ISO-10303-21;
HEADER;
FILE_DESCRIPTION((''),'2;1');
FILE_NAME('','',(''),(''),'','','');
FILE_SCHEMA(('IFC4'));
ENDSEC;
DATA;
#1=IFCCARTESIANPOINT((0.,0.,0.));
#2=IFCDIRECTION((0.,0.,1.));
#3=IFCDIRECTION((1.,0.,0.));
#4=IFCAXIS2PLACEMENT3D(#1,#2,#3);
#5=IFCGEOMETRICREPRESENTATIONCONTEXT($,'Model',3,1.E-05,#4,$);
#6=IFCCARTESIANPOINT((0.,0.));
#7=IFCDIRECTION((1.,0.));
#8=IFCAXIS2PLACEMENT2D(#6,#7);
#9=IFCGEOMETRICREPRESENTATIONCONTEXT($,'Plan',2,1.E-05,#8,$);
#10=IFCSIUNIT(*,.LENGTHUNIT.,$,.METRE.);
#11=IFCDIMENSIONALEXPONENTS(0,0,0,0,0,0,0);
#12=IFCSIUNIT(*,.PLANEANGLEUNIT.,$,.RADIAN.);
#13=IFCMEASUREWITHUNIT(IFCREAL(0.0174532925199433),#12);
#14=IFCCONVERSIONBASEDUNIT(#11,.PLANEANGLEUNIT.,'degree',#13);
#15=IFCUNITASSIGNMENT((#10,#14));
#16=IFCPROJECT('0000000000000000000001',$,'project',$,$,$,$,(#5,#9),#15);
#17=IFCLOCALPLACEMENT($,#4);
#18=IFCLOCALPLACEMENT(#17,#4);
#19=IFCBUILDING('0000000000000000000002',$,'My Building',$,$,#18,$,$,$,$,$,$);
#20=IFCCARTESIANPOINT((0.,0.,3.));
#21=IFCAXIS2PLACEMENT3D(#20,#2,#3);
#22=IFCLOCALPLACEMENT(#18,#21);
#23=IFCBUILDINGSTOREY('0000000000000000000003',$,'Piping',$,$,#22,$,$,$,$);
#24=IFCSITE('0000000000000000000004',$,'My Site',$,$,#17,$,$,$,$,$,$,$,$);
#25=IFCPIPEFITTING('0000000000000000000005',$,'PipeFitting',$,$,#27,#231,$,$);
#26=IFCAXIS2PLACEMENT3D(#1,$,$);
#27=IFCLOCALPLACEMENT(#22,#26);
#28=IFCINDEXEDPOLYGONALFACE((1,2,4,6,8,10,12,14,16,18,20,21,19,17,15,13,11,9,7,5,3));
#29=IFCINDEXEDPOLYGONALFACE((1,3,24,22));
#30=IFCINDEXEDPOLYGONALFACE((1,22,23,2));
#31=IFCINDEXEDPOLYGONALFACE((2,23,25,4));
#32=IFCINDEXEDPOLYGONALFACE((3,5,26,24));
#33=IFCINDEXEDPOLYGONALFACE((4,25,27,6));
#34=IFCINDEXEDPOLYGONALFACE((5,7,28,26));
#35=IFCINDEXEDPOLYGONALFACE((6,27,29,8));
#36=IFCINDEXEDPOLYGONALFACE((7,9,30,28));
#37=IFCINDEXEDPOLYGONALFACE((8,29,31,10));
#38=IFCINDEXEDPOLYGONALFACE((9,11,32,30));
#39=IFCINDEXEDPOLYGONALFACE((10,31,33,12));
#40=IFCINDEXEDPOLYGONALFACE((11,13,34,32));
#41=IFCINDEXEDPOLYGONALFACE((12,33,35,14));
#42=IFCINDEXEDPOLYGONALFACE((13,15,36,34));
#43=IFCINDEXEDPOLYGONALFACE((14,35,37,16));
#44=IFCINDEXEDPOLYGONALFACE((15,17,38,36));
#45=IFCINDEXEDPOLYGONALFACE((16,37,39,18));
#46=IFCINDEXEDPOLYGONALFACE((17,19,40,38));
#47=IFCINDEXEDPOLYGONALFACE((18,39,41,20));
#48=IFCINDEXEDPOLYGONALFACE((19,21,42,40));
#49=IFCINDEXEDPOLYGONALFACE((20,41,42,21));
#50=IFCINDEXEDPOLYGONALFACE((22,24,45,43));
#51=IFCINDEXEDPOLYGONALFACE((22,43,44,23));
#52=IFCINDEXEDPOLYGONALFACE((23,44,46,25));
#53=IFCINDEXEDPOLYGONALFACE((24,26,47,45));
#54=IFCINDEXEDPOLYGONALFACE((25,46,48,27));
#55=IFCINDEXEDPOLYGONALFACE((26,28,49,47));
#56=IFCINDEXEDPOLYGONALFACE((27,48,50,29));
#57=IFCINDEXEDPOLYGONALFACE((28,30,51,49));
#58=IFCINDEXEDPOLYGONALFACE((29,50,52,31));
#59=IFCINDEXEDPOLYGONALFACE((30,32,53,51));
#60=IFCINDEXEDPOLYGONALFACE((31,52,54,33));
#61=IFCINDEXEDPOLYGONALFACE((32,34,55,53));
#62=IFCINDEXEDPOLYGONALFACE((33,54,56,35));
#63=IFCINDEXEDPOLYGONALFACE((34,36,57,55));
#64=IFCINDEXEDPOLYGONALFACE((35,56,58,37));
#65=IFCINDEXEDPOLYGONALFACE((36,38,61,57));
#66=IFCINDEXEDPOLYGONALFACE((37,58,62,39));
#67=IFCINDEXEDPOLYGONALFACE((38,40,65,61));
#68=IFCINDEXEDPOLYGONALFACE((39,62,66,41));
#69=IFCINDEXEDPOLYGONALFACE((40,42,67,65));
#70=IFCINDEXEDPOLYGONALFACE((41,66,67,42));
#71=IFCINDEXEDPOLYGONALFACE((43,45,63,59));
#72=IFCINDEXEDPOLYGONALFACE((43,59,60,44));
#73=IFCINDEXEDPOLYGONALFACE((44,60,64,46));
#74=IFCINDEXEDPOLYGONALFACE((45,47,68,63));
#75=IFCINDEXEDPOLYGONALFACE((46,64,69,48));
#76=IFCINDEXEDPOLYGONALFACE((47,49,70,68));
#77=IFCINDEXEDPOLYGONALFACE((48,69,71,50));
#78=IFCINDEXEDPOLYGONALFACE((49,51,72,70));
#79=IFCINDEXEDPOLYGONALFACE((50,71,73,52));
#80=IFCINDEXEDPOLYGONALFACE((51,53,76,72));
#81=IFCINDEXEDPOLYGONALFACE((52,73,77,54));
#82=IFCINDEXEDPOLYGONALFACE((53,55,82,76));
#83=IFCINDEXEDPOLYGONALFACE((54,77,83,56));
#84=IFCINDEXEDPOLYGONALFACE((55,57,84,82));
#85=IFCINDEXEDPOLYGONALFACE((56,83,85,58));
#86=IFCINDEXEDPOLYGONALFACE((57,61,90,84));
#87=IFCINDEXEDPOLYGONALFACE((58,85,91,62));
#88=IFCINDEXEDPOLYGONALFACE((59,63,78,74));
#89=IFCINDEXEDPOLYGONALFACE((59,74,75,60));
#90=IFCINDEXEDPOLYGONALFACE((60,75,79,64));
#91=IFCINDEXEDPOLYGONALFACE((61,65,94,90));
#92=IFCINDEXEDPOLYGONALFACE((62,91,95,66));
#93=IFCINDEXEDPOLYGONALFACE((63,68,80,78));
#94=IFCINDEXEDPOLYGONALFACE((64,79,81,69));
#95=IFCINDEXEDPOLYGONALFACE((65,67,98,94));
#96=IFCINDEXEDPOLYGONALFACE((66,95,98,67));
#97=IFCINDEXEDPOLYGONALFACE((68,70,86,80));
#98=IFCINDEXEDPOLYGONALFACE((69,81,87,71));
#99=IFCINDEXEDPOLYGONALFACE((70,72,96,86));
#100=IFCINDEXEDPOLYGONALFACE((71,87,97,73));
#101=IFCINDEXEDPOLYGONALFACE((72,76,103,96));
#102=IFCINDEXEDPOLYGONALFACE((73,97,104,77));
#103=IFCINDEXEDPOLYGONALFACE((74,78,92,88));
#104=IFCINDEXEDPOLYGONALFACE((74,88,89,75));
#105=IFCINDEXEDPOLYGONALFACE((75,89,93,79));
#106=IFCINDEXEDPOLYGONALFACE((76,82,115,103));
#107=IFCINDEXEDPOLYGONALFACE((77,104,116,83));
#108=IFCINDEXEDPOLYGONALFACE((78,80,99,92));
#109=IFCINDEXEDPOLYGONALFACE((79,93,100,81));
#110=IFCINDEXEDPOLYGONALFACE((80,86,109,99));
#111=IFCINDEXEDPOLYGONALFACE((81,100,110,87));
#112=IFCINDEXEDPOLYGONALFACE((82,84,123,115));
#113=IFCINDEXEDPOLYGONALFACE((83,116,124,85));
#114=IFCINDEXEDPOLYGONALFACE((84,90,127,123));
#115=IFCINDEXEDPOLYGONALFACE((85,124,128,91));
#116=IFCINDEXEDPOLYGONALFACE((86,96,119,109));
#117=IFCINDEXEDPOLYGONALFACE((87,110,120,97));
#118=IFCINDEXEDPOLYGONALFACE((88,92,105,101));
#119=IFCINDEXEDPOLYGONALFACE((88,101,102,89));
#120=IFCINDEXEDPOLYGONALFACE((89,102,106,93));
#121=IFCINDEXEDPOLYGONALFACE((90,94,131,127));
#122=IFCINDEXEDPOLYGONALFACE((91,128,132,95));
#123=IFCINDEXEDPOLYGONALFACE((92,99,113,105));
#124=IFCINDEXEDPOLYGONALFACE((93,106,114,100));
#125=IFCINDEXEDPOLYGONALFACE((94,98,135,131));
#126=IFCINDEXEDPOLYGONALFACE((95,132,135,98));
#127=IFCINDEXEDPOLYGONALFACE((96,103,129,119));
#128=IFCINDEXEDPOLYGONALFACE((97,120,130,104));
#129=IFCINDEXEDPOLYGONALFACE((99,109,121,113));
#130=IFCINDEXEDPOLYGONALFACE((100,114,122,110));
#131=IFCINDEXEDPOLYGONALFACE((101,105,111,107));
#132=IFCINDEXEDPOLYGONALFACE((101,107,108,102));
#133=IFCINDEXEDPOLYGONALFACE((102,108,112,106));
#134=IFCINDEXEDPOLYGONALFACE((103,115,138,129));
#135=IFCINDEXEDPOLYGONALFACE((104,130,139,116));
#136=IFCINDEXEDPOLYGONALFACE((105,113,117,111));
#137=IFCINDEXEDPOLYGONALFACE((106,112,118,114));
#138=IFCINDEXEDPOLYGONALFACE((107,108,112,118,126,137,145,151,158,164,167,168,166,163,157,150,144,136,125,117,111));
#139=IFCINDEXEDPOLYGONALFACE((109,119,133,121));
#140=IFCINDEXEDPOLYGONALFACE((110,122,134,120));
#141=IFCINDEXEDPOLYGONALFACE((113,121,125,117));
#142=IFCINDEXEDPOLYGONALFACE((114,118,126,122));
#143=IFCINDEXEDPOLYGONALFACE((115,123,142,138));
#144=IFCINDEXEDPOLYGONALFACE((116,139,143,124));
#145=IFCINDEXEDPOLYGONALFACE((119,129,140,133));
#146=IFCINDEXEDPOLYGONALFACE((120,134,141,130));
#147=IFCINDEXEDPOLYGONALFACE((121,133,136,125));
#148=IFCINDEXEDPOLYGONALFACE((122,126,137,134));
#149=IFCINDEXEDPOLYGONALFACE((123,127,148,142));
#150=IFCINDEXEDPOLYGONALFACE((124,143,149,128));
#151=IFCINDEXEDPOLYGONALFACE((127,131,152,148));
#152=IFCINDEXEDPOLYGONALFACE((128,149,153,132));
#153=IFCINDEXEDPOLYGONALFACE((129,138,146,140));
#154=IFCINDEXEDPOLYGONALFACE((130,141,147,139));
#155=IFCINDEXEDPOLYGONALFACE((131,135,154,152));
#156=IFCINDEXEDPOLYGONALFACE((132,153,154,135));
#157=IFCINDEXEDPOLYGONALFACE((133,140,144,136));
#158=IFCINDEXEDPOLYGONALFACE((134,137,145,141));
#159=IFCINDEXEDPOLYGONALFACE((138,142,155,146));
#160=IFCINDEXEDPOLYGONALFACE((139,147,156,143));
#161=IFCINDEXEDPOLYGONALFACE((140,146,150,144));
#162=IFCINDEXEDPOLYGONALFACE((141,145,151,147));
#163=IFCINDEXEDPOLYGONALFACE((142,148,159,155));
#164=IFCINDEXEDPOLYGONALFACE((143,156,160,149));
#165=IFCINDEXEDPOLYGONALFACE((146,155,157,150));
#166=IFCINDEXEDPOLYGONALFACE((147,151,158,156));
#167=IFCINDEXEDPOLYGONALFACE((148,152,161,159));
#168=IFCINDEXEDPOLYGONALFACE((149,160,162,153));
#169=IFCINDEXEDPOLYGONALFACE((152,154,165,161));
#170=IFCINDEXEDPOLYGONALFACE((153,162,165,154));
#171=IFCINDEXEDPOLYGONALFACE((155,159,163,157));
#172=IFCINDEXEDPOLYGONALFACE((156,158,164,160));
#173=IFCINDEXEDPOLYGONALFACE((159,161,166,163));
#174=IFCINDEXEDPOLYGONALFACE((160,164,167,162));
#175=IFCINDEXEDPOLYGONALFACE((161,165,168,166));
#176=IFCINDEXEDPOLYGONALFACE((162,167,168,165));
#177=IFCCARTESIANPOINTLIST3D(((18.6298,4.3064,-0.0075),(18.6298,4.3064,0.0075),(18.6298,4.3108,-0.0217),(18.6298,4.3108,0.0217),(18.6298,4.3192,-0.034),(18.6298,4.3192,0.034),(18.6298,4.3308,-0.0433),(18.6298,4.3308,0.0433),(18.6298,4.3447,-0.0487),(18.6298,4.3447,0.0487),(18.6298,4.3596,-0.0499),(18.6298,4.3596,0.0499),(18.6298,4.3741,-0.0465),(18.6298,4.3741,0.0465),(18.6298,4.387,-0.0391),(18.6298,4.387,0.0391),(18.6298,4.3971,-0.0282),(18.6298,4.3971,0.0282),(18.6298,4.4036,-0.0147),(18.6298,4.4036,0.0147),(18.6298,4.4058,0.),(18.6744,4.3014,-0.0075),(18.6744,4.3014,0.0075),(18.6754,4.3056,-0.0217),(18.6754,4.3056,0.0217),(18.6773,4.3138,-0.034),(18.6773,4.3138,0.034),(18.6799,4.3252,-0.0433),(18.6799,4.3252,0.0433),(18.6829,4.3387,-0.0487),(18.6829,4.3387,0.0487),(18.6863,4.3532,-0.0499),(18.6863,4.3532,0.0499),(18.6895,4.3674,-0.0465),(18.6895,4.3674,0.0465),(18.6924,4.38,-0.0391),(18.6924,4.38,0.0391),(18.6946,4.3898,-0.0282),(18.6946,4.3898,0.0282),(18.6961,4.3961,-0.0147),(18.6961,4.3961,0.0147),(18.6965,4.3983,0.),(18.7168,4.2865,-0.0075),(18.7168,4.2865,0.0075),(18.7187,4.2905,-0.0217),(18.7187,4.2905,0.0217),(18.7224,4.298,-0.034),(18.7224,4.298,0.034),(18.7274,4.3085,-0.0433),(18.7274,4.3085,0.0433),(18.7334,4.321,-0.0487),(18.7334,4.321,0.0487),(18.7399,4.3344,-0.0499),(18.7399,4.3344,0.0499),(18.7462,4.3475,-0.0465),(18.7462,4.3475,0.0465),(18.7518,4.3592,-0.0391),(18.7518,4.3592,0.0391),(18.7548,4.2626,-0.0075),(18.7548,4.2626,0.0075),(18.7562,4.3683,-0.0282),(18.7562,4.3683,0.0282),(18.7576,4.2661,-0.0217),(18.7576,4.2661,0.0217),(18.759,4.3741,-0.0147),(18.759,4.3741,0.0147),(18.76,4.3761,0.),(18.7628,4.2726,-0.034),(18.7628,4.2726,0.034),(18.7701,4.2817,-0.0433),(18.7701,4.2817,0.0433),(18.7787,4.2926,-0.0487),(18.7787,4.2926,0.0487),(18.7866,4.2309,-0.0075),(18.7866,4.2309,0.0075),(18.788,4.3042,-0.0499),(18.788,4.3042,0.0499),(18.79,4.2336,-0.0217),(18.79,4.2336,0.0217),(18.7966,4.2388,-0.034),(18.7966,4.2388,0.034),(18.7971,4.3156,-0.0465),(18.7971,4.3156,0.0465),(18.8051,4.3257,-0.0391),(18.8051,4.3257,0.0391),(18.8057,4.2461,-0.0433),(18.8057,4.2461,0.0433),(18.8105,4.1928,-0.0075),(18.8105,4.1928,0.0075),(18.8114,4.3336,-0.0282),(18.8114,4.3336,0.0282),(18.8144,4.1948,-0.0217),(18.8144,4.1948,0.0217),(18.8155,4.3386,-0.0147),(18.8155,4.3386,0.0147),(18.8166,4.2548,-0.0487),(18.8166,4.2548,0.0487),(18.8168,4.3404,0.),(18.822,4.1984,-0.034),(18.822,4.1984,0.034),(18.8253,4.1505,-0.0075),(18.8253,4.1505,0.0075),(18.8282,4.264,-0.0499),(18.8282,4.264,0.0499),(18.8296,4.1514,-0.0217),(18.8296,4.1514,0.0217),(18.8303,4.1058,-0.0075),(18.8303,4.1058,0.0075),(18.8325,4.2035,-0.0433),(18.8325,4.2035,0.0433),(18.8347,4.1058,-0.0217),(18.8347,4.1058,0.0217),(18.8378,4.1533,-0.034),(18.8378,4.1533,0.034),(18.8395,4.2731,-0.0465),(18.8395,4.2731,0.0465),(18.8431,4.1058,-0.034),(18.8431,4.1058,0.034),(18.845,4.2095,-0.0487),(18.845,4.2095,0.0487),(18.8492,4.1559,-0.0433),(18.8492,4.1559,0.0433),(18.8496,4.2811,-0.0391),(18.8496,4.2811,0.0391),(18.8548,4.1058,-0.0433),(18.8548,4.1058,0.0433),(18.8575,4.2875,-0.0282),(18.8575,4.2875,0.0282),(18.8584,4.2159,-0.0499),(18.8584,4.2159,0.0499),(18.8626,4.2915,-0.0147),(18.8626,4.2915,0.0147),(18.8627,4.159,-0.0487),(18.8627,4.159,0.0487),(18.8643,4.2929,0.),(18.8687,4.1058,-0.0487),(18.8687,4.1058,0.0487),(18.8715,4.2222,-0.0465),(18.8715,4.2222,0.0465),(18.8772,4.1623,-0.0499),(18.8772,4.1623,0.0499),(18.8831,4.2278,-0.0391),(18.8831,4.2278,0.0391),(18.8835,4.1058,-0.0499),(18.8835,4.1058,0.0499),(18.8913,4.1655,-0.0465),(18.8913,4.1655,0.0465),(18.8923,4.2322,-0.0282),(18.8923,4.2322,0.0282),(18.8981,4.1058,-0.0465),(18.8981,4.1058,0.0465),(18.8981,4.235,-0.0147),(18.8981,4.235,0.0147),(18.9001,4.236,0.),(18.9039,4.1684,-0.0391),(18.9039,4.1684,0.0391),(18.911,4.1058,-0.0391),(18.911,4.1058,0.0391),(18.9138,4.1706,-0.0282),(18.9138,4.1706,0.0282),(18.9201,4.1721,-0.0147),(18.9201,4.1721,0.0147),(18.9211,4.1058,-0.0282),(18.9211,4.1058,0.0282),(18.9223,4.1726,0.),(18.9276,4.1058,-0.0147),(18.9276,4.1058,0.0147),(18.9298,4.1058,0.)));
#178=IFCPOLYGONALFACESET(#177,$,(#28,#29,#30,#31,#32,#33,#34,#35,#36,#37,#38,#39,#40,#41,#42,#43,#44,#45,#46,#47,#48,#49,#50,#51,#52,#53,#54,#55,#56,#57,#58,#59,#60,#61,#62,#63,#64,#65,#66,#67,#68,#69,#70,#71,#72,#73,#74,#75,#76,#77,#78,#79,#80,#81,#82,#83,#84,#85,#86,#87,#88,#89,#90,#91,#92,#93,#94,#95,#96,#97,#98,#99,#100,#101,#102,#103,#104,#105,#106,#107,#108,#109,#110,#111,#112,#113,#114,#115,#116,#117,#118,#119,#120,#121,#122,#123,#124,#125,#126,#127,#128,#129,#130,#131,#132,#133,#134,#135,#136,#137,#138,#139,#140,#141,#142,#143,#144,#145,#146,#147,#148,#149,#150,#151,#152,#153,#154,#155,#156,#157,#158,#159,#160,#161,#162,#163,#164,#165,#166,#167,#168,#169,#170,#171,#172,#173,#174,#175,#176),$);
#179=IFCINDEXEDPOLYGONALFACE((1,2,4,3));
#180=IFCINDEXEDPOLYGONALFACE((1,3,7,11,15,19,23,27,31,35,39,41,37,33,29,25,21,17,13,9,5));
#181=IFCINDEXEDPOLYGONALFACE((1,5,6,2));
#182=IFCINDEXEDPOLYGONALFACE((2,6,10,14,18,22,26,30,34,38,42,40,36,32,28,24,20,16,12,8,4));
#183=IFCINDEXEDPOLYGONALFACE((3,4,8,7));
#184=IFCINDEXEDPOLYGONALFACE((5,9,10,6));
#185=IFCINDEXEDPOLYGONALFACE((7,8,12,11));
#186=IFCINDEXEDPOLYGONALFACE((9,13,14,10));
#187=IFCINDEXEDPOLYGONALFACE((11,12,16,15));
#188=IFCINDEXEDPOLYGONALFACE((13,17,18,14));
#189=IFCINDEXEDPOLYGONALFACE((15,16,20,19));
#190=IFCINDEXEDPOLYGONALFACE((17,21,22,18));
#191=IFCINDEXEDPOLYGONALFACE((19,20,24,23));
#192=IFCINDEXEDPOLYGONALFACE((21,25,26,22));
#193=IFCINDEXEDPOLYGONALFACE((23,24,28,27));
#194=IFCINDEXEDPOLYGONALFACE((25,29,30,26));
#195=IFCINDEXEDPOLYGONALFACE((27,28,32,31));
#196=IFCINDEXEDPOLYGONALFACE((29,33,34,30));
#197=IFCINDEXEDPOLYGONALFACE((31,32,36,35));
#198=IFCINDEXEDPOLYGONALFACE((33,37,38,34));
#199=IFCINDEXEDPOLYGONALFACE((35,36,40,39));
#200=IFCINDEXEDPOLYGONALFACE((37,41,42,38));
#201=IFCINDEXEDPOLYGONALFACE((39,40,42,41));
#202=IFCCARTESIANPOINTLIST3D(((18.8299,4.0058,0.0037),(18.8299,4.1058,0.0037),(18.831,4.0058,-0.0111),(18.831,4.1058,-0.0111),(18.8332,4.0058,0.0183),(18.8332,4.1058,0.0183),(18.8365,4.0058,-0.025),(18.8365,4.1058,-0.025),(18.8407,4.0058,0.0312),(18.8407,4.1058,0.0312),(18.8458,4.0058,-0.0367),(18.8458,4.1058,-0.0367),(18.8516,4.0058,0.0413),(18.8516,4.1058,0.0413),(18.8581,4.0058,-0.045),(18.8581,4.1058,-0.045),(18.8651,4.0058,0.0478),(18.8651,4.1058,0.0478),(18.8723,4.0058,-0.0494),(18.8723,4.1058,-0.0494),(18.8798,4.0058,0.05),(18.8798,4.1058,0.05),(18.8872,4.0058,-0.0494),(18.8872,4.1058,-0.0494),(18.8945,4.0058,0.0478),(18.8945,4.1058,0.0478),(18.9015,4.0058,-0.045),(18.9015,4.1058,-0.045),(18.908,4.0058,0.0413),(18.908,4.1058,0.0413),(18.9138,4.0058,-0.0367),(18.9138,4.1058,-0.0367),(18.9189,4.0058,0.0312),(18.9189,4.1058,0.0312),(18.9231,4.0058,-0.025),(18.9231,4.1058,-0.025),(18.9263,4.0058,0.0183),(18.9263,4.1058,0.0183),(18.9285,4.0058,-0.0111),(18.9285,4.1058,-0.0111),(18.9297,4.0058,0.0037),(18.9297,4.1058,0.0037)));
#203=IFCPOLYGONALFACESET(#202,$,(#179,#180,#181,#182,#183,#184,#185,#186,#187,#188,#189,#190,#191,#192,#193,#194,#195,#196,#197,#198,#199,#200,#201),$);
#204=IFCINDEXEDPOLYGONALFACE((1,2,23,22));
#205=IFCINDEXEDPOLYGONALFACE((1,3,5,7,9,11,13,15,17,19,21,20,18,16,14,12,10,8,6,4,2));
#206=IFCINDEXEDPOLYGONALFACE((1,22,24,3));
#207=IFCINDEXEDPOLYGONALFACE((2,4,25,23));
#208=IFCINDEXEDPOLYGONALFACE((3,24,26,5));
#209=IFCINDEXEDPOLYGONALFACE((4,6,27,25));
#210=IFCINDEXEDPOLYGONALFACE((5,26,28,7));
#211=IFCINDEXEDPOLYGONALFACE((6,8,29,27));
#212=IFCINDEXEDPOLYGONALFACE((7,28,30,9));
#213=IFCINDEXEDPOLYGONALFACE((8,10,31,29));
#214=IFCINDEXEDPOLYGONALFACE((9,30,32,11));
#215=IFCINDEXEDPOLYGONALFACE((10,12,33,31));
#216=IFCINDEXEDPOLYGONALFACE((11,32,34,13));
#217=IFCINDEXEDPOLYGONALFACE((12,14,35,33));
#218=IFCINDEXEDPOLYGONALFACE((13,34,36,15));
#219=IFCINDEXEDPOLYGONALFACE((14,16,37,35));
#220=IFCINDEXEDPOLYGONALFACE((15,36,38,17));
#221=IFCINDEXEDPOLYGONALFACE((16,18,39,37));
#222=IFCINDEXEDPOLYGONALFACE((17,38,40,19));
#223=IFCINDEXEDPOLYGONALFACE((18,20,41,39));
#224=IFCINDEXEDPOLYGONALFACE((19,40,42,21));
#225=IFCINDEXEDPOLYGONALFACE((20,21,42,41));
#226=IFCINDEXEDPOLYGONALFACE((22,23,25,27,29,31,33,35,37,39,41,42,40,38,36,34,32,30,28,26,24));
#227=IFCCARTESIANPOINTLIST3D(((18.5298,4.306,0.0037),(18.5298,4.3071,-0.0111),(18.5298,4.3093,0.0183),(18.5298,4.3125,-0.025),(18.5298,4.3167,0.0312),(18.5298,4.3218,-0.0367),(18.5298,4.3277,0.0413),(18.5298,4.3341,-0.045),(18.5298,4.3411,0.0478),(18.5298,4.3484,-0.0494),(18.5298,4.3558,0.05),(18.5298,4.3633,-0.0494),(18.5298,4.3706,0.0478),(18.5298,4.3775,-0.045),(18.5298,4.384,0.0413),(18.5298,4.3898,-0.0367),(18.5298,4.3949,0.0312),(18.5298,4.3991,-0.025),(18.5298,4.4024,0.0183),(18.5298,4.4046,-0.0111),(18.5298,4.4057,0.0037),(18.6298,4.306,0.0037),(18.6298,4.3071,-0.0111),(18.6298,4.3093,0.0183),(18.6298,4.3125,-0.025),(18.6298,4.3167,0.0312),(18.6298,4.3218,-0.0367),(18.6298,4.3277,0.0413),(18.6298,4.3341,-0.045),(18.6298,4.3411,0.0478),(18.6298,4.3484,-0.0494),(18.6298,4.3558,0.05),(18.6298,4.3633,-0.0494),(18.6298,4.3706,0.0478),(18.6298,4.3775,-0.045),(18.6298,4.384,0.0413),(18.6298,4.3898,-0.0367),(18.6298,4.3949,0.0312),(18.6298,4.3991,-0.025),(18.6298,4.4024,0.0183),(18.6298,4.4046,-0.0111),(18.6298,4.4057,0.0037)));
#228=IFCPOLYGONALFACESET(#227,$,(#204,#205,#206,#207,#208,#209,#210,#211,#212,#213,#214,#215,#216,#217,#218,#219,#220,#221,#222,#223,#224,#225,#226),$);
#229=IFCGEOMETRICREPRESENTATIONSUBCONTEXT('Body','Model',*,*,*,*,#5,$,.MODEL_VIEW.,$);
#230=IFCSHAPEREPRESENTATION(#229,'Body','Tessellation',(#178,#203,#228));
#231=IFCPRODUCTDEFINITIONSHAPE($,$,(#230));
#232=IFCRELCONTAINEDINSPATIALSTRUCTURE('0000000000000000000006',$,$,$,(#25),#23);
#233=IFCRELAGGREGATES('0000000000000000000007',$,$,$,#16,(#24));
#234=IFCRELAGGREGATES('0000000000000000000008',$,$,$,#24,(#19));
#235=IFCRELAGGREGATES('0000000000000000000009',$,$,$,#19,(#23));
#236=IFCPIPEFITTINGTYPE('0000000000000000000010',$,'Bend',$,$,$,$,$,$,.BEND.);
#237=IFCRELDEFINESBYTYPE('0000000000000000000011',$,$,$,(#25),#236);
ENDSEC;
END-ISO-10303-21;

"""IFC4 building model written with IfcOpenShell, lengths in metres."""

from ifc_helpers import new_model, entity, si_unit, converted_unit, frame, origin_with_axes, origin_2d_with_axis, place, context, subcontext, project, spatial, circle, extrude, source, transform, mapped, type_object, type_shapes, element, save


model = new_model("IFC4")

# Units and contexts
model_context = context("Model", 3, precision=1e-05, world=origin_with_axes())
plan_context = context("Plan", 2, precision=1e-05, world=origin_2d_with_axis())
body_context = subcontext(model_context, "Body", "Model", "MODEL_VIEW")
ifc_project = project(units=[si_unit("LENGTHUNIT", "METRE"), converted_unit("PLANEANGLEUNIT", "degree", entity("IfcReal", 0.0174532925199433), si_unit("PLANEANGLEUNIT", "RADIAN"), dimensions=[0, 0, 0, 0, 0, 0, 0])], contexts=[model_context, plan_context])

# Site, building, storey
site_placement = place(None, origin_with_axes())
site = spatial("IfcSite", under=ifc_project, at=site_placement, Name="My Site")
building_placement = place(site_placement, origin_with_axes())
building = spatial("IfcBuilding", under=site, at=building_placement, Name="My Building")
storey_placement = place(building_placement, frame((0.0, 0.0, 3.0), z_axis=(0.0, 0.0, 1.0), x_axis=(1.0, 0.0, 0.0)))
storey = spatial("IfcBuildingStorey", under=building, at=storey_placement, Name="Piping")

# Pipe fitting
pipe_fitting_type_1 = type_object("IfcPipeFittingType", Name="Bend", PredefinedType="BEND")
shared_shape = source(origin_with_axes(), body_context, "Body", "SolidModel", [
    entity("IfcSweptDiskSolid", entity("IfcIndexedPolyCurve", entity("IfcCartesianPointList3D", [[0.0, 0.0, -0.1], [0.0, 0.0732, -0.2768], [0.0, 0.25, -0.35]]), [entity("IfcArcIndex", [1, 2, 3])]), 0.05),
    extrude(circle(Radius=0.05), origin_with_axes(), (0.0, 0.0, -1.0), 0.1),
    extrude(circle(Radius=0.05), frame((0.0, 0.25, -0.35), z_axis=(0.0, 1.0, 0.0), x_axis=(1.0, 0.0, 0.0)), (0.0, 0.0, 1.0), 0.1),
])
type_shapes(pipe_fitting_type_1, [shared_shape])
for number, where, z_axis, x_axis, name in (
    (1, (18.8798, 4.0058, 0.0), (0.0, -1.0, 0.0), (0.0, 0.0, 1.0), "PipeFitting"),
):
    element("IfcPipeFitting", number, at=place(storey_placement, frame(where, z_axis=z_axis, x_axis=x_axis)), inside=storey, type_object=pipe_fitting_type_1, Name=name, context=body_context, shape_type="MappedRepresentation", body=[
        mapped(shared_shape, transform((0.0, 0.0, 0.0), x_axis=(1.0, 0.0, 0.0), y_axis=(0.0, 1.0, 0.0), z_axis=(0.0, 0.0, 1.0), scale=1.0)),
    ])

save(model, "model.ifc")
